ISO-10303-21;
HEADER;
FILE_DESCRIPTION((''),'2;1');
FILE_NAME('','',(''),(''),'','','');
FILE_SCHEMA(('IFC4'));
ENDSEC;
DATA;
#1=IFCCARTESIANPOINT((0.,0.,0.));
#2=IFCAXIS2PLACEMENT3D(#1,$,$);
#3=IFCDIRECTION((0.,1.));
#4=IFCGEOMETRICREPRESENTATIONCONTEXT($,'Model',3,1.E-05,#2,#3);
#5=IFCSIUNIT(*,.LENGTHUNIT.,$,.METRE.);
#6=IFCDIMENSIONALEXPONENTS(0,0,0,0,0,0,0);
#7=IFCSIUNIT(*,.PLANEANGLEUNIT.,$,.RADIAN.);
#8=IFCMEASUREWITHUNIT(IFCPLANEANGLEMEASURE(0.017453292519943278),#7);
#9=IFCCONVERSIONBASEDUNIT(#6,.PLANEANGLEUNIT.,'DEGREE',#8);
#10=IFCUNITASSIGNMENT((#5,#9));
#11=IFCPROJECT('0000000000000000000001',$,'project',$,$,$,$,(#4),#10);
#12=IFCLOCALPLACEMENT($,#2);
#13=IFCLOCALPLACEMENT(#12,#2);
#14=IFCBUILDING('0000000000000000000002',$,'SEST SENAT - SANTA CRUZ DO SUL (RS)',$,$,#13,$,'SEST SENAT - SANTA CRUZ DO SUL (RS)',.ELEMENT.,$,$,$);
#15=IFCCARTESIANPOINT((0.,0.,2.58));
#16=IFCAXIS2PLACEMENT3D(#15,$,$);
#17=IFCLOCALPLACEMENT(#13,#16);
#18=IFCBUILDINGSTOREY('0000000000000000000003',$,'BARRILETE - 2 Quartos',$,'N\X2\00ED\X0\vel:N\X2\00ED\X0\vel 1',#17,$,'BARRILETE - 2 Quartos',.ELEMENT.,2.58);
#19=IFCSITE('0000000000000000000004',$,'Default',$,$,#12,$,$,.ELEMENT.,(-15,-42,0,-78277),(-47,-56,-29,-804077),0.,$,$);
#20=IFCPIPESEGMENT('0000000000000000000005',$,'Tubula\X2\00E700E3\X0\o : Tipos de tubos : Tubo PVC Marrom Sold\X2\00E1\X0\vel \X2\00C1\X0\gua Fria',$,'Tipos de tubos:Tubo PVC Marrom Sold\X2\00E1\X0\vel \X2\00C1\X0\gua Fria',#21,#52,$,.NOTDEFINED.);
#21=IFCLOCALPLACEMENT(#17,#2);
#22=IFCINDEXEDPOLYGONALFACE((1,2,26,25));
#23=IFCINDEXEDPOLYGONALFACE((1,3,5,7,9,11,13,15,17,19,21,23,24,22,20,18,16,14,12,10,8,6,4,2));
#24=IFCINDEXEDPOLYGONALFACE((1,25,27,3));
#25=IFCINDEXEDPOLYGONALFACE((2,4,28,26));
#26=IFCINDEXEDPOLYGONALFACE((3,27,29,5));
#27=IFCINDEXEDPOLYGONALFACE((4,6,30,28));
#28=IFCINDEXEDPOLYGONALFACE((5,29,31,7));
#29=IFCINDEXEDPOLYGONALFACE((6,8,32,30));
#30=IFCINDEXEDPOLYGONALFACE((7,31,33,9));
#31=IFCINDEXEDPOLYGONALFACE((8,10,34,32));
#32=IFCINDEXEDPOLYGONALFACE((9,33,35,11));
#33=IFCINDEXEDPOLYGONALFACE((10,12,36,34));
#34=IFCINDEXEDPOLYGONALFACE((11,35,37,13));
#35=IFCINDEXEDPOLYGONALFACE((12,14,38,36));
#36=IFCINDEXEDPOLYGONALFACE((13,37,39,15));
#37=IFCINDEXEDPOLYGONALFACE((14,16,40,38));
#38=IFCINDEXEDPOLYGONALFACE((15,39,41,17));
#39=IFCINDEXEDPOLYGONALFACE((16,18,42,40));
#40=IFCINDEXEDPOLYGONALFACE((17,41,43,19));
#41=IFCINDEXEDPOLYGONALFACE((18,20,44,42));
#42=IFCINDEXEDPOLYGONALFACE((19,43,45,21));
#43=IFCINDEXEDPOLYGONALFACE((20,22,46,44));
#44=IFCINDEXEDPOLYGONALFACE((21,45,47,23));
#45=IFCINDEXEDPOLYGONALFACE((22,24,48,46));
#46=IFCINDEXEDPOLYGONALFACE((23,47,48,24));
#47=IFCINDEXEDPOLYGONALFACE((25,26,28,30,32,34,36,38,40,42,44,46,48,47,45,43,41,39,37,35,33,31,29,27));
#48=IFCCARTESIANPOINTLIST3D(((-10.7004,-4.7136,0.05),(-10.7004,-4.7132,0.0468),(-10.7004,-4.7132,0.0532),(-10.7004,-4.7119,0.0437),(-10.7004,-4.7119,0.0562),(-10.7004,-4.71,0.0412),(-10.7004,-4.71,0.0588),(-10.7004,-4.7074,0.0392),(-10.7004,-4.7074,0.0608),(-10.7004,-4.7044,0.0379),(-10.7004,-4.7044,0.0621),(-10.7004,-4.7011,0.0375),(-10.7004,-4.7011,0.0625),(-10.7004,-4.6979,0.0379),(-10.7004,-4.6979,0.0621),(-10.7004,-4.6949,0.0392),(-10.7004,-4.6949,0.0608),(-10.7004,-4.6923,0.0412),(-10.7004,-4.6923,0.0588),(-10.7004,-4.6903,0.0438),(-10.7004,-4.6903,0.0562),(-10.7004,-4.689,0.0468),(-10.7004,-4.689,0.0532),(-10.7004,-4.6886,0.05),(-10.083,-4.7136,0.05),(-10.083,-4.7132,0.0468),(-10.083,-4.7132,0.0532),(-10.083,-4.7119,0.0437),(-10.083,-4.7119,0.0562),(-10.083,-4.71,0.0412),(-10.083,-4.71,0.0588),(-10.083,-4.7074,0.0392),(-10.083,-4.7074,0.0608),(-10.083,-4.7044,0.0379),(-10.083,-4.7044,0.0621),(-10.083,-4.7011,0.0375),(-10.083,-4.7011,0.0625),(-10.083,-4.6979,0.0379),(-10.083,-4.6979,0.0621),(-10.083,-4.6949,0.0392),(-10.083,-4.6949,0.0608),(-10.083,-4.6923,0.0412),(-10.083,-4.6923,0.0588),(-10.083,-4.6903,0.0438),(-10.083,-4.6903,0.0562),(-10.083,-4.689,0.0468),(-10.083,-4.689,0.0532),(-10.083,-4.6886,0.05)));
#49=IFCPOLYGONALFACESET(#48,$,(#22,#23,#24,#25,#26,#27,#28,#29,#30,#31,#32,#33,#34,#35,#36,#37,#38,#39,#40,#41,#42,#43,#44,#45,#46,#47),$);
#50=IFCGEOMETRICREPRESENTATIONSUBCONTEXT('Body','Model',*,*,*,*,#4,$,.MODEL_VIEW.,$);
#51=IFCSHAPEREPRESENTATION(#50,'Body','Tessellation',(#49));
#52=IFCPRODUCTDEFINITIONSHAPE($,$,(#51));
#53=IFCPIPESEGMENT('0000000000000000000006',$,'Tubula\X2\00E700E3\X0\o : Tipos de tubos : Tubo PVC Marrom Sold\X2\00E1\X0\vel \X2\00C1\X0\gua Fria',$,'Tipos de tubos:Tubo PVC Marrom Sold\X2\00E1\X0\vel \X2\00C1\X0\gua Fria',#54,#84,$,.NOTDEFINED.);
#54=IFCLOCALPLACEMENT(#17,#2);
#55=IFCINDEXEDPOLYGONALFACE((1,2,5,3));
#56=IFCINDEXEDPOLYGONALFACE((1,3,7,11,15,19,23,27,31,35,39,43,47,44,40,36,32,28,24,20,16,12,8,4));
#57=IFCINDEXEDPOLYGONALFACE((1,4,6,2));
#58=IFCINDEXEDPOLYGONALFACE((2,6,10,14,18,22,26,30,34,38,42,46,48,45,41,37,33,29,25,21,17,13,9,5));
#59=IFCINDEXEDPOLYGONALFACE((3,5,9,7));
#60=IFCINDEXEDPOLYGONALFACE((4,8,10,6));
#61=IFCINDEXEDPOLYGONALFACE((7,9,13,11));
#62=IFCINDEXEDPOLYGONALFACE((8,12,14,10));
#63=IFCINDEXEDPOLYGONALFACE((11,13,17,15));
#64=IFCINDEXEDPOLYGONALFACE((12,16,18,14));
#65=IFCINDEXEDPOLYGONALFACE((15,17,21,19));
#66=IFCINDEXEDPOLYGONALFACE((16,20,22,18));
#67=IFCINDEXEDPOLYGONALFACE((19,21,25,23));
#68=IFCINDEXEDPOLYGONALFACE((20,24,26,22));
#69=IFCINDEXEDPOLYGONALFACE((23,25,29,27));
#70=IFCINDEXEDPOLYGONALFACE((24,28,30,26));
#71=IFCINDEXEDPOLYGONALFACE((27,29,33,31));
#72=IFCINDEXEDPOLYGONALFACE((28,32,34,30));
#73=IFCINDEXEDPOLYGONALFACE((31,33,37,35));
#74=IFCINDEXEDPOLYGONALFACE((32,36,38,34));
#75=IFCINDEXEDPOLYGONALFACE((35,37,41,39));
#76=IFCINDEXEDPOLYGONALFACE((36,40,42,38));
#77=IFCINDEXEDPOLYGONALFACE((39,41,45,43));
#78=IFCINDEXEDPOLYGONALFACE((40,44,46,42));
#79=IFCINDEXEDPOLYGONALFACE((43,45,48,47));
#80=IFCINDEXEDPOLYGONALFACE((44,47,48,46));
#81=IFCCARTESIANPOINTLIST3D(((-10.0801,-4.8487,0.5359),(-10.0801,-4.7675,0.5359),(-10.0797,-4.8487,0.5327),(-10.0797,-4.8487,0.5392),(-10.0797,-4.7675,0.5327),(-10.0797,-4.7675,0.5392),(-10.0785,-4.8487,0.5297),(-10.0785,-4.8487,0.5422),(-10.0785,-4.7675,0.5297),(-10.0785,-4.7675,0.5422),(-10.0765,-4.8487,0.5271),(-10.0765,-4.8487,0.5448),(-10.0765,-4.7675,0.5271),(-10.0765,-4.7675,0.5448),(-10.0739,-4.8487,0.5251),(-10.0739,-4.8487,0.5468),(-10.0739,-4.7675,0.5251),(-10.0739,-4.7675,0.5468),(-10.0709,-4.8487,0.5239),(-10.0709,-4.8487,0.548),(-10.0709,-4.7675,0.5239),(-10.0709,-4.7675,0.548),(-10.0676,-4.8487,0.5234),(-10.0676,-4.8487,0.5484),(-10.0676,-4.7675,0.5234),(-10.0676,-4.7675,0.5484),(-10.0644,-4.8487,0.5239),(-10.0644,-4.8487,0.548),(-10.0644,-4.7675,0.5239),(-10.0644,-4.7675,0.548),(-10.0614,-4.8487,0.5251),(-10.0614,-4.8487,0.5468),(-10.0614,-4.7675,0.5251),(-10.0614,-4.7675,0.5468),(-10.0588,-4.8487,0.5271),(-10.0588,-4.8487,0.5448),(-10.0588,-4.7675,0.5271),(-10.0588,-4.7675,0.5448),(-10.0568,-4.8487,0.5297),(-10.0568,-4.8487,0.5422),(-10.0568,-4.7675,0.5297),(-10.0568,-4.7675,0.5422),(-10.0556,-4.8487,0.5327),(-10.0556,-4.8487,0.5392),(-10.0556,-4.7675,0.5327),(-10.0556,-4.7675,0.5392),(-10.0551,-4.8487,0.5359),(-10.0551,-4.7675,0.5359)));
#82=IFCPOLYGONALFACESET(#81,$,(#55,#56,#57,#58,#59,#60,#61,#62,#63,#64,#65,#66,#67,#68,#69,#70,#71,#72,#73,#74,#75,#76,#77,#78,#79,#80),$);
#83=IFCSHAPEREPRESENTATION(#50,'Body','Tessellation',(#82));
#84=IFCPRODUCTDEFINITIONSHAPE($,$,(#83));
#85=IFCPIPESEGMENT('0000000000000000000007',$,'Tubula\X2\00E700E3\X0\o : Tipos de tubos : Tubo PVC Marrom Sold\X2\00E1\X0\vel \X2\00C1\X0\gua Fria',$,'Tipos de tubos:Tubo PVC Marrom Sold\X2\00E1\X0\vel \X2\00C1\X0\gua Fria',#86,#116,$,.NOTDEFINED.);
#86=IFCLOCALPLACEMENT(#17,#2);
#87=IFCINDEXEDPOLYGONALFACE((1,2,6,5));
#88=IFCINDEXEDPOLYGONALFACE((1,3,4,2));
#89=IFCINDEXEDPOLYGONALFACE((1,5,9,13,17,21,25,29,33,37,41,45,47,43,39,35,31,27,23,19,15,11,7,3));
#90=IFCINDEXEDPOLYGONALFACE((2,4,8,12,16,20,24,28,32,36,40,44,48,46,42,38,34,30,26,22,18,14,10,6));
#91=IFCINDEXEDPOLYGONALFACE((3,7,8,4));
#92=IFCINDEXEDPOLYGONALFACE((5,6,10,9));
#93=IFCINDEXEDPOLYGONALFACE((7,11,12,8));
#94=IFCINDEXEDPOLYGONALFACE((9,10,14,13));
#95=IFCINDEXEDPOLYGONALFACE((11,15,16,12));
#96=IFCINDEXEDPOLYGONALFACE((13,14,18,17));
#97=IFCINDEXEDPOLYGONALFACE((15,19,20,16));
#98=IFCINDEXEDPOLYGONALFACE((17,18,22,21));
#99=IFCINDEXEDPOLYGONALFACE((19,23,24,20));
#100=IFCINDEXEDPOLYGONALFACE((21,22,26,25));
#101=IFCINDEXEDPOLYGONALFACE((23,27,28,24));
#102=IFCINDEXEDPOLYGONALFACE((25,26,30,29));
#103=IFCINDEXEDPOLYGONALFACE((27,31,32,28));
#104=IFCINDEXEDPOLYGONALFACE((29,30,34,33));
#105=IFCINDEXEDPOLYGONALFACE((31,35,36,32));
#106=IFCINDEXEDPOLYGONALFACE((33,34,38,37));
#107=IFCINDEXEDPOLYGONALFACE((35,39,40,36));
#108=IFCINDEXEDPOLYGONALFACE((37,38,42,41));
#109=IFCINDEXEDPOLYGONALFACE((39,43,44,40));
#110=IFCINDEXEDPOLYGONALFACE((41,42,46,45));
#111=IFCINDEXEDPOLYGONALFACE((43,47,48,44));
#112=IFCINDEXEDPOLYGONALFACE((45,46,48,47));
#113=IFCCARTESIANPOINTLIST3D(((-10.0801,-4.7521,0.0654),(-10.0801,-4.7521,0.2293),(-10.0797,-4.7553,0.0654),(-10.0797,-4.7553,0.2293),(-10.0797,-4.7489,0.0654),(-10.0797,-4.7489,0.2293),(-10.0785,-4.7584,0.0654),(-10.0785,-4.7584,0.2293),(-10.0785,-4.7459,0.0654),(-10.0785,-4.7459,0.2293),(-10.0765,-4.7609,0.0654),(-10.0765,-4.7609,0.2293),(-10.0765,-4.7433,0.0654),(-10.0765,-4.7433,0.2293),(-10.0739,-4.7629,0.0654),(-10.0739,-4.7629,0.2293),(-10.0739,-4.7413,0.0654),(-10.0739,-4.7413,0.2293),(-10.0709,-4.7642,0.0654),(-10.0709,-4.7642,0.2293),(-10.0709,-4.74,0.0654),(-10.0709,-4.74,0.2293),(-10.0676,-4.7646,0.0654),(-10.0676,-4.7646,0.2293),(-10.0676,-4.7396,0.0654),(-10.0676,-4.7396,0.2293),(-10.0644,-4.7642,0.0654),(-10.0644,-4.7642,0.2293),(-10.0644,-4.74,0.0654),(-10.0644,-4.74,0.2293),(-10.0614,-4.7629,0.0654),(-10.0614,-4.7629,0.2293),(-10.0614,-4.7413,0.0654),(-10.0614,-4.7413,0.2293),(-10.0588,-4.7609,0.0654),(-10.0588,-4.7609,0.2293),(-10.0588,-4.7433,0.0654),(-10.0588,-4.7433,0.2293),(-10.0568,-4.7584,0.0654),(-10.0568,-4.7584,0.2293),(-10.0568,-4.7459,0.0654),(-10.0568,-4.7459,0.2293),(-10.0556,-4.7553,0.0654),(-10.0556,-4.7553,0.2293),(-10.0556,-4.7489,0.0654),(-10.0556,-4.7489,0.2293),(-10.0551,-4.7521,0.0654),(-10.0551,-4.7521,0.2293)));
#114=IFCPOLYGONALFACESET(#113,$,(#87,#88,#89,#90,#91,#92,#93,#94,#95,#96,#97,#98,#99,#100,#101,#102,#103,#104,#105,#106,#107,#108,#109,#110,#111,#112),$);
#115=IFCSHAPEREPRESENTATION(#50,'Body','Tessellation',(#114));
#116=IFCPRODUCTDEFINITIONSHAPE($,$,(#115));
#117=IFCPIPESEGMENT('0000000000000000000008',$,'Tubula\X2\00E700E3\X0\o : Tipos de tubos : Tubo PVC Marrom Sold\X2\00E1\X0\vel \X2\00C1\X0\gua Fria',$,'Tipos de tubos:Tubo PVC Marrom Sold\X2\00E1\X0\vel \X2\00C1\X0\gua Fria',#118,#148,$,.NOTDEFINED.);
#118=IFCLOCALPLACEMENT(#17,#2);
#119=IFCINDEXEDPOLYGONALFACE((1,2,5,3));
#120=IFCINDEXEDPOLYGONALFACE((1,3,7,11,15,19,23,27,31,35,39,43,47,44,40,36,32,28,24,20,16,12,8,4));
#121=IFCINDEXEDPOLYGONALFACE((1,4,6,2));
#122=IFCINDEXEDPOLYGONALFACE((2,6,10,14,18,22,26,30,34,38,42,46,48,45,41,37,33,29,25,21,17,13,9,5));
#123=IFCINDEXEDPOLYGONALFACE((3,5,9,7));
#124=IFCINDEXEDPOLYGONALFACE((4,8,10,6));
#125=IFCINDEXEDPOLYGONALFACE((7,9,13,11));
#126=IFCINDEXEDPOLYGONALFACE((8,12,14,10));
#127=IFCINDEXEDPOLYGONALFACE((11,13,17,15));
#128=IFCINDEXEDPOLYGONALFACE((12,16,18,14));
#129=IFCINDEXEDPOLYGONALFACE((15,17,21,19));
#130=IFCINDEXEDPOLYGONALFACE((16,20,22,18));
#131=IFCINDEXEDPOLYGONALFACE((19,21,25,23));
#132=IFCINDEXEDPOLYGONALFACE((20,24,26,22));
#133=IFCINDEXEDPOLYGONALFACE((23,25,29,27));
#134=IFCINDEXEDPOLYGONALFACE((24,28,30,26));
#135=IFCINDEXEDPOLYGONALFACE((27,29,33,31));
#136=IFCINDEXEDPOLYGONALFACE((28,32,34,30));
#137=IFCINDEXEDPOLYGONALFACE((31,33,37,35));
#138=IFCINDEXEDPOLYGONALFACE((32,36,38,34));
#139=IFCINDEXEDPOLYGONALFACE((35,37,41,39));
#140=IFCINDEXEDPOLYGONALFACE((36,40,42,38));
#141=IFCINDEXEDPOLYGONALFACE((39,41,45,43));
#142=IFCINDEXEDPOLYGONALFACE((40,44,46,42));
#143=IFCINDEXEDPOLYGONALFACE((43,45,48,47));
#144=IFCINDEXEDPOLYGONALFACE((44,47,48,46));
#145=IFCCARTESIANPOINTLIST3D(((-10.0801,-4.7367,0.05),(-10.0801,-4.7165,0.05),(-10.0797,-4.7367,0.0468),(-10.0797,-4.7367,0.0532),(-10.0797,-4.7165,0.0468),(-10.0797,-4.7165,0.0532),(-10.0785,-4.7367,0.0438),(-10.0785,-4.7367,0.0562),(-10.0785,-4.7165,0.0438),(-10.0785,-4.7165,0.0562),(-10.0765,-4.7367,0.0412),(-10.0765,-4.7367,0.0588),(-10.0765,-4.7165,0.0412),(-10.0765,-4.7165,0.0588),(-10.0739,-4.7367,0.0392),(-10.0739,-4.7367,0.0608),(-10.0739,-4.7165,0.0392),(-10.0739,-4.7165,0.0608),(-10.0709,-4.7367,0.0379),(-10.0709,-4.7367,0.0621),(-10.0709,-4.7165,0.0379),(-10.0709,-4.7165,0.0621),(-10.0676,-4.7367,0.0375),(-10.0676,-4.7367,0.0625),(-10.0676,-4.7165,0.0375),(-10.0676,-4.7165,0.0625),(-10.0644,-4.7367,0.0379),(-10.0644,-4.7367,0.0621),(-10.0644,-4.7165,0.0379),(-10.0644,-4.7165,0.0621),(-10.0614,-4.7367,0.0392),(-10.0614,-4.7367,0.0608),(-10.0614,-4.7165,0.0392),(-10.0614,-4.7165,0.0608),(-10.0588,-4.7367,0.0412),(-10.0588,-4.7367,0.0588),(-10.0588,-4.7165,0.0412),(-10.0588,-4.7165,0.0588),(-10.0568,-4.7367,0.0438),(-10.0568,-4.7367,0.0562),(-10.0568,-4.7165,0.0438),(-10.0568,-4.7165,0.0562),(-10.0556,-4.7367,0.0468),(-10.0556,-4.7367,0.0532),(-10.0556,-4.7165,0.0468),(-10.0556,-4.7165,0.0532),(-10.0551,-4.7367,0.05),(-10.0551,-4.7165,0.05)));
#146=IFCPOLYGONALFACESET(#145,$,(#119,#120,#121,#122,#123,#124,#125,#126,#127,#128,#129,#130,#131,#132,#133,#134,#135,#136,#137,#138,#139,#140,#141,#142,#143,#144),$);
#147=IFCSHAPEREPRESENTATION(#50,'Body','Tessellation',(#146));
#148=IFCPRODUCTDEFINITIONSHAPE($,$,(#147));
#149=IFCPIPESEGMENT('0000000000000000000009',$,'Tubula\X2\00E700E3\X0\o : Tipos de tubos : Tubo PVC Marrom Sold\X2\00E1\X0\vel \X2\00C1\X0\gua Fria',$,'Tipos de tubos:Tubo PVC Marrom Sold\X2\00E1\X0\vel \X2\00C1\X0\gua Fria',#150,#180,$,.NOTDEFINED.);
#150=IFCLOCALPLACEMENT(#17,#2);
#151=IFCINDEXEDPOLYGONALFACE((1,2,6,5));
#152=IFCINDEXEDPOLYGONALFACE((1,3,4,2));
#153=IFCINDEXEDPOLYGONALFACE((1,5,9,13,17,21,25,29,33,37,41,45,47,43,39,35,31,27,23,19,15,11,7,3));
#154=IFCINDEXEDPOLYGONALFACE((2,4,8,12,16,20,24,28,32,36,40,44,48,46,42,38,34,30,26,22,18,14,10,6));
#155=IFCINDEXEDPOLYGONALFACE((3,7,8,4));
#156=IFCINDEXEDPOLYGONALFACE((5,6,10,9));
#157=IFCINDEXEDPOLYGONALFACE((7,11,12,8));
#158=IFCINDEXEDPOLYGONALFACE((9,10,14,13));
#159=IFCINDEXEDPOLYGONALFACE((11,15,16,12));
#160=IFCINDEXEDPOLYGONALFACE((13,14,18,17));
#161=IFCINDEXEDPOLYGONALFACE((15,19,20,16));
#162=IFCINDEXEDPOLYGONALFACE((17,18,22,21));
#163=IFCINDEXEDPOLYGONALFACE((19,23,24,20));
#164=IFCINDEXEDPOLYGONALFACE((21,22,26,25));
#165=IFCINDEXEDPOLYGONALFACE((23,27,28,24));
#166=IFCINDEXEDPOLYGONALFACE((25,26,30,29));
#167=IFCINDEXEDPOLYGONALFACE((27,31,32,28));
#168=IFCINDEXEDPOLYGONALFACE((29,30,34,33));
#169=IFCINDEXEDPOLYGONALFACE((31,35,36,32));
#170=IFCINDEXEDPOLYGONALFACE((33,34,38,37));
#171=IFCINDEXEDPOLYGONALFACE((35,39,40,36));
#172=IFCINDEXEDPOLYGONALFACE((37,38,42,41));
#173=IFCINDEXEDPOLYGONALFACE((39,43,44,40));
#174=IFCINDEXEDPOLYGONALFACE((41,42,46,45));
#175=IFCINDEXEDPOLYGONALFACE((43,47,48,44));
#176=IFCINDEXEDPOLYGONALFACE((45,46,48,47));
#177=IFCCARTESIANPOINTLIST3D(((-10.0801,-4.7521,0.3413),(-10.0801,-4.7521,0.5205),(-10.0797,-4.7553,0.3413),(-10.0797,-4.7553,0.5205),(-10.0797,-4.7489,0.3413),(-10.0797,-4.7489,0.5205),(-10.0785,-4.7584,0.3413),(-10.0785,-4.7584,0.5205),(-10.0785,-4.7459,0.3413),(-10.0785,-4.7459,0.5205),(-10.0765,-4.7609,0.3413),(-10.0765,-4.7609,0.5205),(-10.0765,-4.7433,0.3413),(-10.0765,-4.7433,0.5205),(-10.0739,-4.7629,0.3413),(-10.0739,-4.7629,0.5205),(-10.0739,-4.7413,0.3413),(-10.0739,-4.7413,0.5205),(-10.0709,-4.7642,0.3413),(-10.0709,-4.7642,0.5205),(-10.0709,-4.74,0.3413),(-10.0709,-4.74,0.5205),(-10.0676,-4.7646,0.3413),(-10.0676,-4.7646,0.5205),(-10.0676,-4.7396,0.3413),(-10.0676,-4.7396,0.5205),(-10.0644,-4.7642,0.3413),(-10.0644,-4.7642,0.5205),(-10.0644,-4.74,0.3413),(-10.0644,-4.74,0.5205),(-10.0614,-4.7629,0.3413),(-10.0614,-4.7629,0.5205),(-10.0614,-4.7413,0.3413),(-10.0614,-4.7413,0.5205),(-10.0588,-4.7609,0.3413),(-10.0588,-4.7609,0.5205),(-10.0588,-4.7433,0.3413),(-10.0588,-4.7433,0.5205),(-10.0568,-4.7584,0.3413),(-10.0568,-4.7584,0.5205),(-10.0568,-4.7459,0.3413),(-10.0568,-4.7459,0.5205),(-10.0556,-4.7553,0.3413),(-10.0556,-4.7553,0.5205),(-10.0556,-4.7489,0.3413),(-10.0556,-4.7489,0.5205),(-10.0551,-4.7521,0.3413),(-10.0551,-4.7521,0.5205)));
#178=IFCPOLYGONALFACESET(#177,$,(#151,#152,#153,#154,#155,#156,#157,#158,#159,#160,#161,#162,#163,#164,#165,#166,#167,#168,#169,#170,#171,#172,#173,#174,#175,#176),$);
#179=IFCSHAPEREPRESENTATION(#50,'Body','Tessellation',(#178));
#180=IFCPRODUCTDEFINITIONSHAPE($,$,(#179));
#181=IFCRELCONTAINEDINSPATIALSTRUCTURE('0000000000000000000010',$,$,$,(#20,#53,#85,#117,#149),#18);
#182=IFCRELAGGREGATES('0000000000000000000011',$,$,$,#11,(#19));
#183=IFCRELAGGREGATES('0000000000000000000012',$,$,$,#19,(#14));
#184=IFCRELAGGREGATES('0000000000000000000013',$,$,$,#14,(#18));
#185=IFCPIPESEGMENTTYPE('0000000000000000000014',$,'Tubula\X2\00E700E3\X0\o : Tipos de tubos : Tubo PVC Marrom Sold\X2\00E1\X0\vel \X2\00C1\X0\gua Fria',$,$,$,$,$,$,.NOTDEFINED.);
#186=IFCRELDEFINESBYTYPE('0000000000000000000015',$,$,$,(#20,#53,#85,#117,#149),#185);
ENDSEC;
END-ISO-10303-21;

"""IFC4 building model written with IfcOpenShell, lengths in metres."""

from ifc_helpers import new_model, entity, si_unit, converted_unit, direction, frame, origin, place, context, subcontext, project, spatial, arc, indexed_curve, outline, extrude, type_object, element, save


model = new_model("IFC4")

# Units and contexts
model_context = context("Model", 3, precision=1e-05, world=origin(), true_north=direction((0.0, 1.0)))
body_context = subcontext(model_context, "Body", "Model", "MODEL_VIEW")
ifc_project = project(units=[si_unit("LENGTHUNIT", "METRE"), converted_unit("PLANEANGLEUNIT", "DEGREE", entity("IfcPlaneAngleMeasure", 0.017453292519943278), si_unit("PLANEANGLEUNIT", "RADIAN"), dimensions=[0, 0, 0, 0, 0, 0, 0])], contexts=[model_context])

# Site, building, storey
site_placement = place(None, origin())
site = spatial("IfcSite", under=ifc_project, at=site_placement, Name="Default", CompositionType="ELEMENT", RefLatitude=(-15, -42, 0, -78277), RefLongitude=(-47, -56, -29, -804077), RefElevation=0.0)
building_placement = place(site_placement, origin())
building = spatial("IfcBuilding", under=site, at=building_placement, Name="SEST SENAT - SANTA CRUZ DO SUL (RS)", LongName="SEST SENAT - SANTA CRUZ DO SUL (RS)", CompositionType="ELEMENT")
storey_placement = place(building_placement, frame((0.0, 0.0, 2.58)))
storey = spatial("IfcBuildingStorey", under=building, at=storey_placement, Name="BARRILETE - 2 Quartos", ObjectType="Nível:Nível 1", LongName="BARRILETE - 2 Quartos", CompositionType="ELEMENT", Elevation=2.58)

# Pipe segments
pipe_segment_type = type_object("IfcPipeSegmentType", Name="Tubulação : Tipos de tubos : Tubo PVC Marrom Soldável Água Fria", PredefinedType="NOTDEFINED")
pipe_segment_1_placement = place(storey_placement, frame((-10.7004, -4.7152, 0.0359)))
element("IfcPipeSegment", 1, at=pipe_segment_1_placement, inside=storey, type_object=pipe_segment_type, Name="Tubulação : Tipos de tubos : Tubo PVC Marrom Soldável Água Fria", ObjectType="Tipos de tubos:Tubo PVC Marrom Soldável Água Fria", PredefinedType="NOTDEFINED", context=body_context, shape_type="SweptSolid", body=[
    extrude(outline(indexed_curve([(0.0125, 0.0), (0.0088, 0.0088), (0.0, 0.0125), (-0.0088, 0.0088), (-0.0125, 0.0), (-0.0088, -0.0088), (0.0, -0.0125), (0.0088, -0.0088)], segments=[arc(1, 2, 3), arc(3, 4, 5), arc(5, 6, 7), arc(7, 8, 1)], self_intersect=False)), frame((0.0, 0.0141, 0.0141), z_axis=(1.0, 0.0, 0.0), x_axis=(0.0, 1.0, 0.0)), (0.0, 0.0, 1.0), 0.6174),
])
pipe_segment_2_placement = place(storey_placement, frame((-10.0817, -4.8487, 0.5218)))
element("IfcPipeSegment", 2, at=pipe_segment_2_placement, inside=storey, type_object=pipe_segment_type, Name="Tubulação : Tipos de tubos : Tubo PVC Marrom Soldável Água Fria", ObjectType="Tipos de tubos:Tubo PVC Marrom Soldável Água Fria", PredefinedType="NOTDEFINED", context=body_context, shape_type="SweptSolid", body=[
    extrude(outline(indexed_curve([(0.0125, 0.0), (0.0088, 0.0088), (0.0, 0.0125), (-0.0088, 0.0088), (-0.0125, 0.0), (-0.0088, -0.0088), (0.0, -0.0125), (0.0088, -0.0088)], segments=[arc(1, 2, 3), arc(3, 4, 5), arc(5, 6, 7), arc(7, 8, 1)], self_intersect=False)), frame((0.0141, 0.0, 0.0141), z_axis=(0.0, 1.0, 0.0), x_axis=(1.0, 0.0, 0.0)), (0.0, 0.0, 1.0), 0.0812),
])
pipe_segment_3_placement = place(storey_placement, frame((-10.0817, -4.7662, 0.0654)))
element("IfcPipeSegment", 3, at=pipe_segment_3_placement, inside=storey, type_object=pipe_segment_type, Name="Tubulação : Tipos de tubos : Tubo PVC Marrom Soldável Água Fria", ObjectType="Tipos de tubos:Tubo PVC Marrom Soldável Água Fria", PredefinedType="NOTDEFINED", context=body_context, shape_type="SweptSolid", body=[
    extrude(outline(indexed_curve([(0.0125, 0.0), (0.0088, 0.0088), (0.0, 0.0125), (-0.0088, 0.0088), (-0.0125, 0.0), (-0.0088, -0.0088), (0.0, -0.0125), (0.0088, -0.0088)], segments=[arc(1, 2, 3), arc(3, 4, 5), arc(5, 6, 7), arc(7, 8, 1)], self_intersect=False)), frame((0.0141, 0.0141, 0.0)), (0.0, 0.0, 1.0), 0.1639),
])
pipe_segment_4_placement = place(storey_placement, frame((-10.0817, -4.7367, 0.0359)))
element("IfcPipeSegment", 4, at=pipe_segment_4_placement, inside=storey, type_object=pipe_segment_type, Name="Tubulação : Tipos de tubos : Tubo PVC Marrom Soldável Água Fria", ObjectType="Tipos de tubos:Tubo PVC Marrom Soldável Água Fria", PredefinedType="NOTDEFINED", context=body_context, shape_type="SweptSolid", body=[
    extrude(outline(indexed_curve([(0.0125, 0.0), (0.0088, 0.0088), (0.0, 0.0125), (-0.0088, 0.0088), (-0.0125, 0.0), (-0.0088, -0.0088), (0.0, -0.0125), (0.0088, -0.0088)], segments=[arc(1, 2, 3), arc(3, 4, 5), arc(5, 6, 7), arc(7, 8, 1)], self_intersect=False)), frame((0.0141, 0.0, 0.0141), z_axis=(0.0, 1.0, 0.0), x_axis=(1.0, 0.0, 0.0)), (0.0, 0.0, 1.0), 0.0202),
])
pipe_segment_5_placement = place(storey_placement, frame((-10.0817, -4.7662, 0.3413)))
element("IfcPipeSegment", 5, at=pipe_segment_5_placement, inside=storey, type_object=pipe_segment_type, Name="Tubulação : Tipos de tubos : Tubo PVC Marrom Soldável Água Fria", ObjectType="Tipos de tubos:Tubo PVC Marrom Soldável Água Fria", PredefinedType="NOTDEFINED", context=body_context, shape_type="SweptSolid", body=[
    extrude(outline(indexed_curve([(0.0125, 0.0), (0.0088, 0.0088), (0.0, 0.0125), (-0.0088, 0.0088), (-0.0125, 0.0), (-0.0088, -0.0088), (0.0, -0.0125), (0.0088, -0.0088)], segments=[arc(1, 2, 3), arc(3, 4, 5), arc(5, 6, 7), arc(7, 8, 1)], self_intersect=False)), frame((0.0141, 0.0141, 0.0)), (0.0, 0.0, 1.0), 0.1793),
])

save(model, "model.ifc")
